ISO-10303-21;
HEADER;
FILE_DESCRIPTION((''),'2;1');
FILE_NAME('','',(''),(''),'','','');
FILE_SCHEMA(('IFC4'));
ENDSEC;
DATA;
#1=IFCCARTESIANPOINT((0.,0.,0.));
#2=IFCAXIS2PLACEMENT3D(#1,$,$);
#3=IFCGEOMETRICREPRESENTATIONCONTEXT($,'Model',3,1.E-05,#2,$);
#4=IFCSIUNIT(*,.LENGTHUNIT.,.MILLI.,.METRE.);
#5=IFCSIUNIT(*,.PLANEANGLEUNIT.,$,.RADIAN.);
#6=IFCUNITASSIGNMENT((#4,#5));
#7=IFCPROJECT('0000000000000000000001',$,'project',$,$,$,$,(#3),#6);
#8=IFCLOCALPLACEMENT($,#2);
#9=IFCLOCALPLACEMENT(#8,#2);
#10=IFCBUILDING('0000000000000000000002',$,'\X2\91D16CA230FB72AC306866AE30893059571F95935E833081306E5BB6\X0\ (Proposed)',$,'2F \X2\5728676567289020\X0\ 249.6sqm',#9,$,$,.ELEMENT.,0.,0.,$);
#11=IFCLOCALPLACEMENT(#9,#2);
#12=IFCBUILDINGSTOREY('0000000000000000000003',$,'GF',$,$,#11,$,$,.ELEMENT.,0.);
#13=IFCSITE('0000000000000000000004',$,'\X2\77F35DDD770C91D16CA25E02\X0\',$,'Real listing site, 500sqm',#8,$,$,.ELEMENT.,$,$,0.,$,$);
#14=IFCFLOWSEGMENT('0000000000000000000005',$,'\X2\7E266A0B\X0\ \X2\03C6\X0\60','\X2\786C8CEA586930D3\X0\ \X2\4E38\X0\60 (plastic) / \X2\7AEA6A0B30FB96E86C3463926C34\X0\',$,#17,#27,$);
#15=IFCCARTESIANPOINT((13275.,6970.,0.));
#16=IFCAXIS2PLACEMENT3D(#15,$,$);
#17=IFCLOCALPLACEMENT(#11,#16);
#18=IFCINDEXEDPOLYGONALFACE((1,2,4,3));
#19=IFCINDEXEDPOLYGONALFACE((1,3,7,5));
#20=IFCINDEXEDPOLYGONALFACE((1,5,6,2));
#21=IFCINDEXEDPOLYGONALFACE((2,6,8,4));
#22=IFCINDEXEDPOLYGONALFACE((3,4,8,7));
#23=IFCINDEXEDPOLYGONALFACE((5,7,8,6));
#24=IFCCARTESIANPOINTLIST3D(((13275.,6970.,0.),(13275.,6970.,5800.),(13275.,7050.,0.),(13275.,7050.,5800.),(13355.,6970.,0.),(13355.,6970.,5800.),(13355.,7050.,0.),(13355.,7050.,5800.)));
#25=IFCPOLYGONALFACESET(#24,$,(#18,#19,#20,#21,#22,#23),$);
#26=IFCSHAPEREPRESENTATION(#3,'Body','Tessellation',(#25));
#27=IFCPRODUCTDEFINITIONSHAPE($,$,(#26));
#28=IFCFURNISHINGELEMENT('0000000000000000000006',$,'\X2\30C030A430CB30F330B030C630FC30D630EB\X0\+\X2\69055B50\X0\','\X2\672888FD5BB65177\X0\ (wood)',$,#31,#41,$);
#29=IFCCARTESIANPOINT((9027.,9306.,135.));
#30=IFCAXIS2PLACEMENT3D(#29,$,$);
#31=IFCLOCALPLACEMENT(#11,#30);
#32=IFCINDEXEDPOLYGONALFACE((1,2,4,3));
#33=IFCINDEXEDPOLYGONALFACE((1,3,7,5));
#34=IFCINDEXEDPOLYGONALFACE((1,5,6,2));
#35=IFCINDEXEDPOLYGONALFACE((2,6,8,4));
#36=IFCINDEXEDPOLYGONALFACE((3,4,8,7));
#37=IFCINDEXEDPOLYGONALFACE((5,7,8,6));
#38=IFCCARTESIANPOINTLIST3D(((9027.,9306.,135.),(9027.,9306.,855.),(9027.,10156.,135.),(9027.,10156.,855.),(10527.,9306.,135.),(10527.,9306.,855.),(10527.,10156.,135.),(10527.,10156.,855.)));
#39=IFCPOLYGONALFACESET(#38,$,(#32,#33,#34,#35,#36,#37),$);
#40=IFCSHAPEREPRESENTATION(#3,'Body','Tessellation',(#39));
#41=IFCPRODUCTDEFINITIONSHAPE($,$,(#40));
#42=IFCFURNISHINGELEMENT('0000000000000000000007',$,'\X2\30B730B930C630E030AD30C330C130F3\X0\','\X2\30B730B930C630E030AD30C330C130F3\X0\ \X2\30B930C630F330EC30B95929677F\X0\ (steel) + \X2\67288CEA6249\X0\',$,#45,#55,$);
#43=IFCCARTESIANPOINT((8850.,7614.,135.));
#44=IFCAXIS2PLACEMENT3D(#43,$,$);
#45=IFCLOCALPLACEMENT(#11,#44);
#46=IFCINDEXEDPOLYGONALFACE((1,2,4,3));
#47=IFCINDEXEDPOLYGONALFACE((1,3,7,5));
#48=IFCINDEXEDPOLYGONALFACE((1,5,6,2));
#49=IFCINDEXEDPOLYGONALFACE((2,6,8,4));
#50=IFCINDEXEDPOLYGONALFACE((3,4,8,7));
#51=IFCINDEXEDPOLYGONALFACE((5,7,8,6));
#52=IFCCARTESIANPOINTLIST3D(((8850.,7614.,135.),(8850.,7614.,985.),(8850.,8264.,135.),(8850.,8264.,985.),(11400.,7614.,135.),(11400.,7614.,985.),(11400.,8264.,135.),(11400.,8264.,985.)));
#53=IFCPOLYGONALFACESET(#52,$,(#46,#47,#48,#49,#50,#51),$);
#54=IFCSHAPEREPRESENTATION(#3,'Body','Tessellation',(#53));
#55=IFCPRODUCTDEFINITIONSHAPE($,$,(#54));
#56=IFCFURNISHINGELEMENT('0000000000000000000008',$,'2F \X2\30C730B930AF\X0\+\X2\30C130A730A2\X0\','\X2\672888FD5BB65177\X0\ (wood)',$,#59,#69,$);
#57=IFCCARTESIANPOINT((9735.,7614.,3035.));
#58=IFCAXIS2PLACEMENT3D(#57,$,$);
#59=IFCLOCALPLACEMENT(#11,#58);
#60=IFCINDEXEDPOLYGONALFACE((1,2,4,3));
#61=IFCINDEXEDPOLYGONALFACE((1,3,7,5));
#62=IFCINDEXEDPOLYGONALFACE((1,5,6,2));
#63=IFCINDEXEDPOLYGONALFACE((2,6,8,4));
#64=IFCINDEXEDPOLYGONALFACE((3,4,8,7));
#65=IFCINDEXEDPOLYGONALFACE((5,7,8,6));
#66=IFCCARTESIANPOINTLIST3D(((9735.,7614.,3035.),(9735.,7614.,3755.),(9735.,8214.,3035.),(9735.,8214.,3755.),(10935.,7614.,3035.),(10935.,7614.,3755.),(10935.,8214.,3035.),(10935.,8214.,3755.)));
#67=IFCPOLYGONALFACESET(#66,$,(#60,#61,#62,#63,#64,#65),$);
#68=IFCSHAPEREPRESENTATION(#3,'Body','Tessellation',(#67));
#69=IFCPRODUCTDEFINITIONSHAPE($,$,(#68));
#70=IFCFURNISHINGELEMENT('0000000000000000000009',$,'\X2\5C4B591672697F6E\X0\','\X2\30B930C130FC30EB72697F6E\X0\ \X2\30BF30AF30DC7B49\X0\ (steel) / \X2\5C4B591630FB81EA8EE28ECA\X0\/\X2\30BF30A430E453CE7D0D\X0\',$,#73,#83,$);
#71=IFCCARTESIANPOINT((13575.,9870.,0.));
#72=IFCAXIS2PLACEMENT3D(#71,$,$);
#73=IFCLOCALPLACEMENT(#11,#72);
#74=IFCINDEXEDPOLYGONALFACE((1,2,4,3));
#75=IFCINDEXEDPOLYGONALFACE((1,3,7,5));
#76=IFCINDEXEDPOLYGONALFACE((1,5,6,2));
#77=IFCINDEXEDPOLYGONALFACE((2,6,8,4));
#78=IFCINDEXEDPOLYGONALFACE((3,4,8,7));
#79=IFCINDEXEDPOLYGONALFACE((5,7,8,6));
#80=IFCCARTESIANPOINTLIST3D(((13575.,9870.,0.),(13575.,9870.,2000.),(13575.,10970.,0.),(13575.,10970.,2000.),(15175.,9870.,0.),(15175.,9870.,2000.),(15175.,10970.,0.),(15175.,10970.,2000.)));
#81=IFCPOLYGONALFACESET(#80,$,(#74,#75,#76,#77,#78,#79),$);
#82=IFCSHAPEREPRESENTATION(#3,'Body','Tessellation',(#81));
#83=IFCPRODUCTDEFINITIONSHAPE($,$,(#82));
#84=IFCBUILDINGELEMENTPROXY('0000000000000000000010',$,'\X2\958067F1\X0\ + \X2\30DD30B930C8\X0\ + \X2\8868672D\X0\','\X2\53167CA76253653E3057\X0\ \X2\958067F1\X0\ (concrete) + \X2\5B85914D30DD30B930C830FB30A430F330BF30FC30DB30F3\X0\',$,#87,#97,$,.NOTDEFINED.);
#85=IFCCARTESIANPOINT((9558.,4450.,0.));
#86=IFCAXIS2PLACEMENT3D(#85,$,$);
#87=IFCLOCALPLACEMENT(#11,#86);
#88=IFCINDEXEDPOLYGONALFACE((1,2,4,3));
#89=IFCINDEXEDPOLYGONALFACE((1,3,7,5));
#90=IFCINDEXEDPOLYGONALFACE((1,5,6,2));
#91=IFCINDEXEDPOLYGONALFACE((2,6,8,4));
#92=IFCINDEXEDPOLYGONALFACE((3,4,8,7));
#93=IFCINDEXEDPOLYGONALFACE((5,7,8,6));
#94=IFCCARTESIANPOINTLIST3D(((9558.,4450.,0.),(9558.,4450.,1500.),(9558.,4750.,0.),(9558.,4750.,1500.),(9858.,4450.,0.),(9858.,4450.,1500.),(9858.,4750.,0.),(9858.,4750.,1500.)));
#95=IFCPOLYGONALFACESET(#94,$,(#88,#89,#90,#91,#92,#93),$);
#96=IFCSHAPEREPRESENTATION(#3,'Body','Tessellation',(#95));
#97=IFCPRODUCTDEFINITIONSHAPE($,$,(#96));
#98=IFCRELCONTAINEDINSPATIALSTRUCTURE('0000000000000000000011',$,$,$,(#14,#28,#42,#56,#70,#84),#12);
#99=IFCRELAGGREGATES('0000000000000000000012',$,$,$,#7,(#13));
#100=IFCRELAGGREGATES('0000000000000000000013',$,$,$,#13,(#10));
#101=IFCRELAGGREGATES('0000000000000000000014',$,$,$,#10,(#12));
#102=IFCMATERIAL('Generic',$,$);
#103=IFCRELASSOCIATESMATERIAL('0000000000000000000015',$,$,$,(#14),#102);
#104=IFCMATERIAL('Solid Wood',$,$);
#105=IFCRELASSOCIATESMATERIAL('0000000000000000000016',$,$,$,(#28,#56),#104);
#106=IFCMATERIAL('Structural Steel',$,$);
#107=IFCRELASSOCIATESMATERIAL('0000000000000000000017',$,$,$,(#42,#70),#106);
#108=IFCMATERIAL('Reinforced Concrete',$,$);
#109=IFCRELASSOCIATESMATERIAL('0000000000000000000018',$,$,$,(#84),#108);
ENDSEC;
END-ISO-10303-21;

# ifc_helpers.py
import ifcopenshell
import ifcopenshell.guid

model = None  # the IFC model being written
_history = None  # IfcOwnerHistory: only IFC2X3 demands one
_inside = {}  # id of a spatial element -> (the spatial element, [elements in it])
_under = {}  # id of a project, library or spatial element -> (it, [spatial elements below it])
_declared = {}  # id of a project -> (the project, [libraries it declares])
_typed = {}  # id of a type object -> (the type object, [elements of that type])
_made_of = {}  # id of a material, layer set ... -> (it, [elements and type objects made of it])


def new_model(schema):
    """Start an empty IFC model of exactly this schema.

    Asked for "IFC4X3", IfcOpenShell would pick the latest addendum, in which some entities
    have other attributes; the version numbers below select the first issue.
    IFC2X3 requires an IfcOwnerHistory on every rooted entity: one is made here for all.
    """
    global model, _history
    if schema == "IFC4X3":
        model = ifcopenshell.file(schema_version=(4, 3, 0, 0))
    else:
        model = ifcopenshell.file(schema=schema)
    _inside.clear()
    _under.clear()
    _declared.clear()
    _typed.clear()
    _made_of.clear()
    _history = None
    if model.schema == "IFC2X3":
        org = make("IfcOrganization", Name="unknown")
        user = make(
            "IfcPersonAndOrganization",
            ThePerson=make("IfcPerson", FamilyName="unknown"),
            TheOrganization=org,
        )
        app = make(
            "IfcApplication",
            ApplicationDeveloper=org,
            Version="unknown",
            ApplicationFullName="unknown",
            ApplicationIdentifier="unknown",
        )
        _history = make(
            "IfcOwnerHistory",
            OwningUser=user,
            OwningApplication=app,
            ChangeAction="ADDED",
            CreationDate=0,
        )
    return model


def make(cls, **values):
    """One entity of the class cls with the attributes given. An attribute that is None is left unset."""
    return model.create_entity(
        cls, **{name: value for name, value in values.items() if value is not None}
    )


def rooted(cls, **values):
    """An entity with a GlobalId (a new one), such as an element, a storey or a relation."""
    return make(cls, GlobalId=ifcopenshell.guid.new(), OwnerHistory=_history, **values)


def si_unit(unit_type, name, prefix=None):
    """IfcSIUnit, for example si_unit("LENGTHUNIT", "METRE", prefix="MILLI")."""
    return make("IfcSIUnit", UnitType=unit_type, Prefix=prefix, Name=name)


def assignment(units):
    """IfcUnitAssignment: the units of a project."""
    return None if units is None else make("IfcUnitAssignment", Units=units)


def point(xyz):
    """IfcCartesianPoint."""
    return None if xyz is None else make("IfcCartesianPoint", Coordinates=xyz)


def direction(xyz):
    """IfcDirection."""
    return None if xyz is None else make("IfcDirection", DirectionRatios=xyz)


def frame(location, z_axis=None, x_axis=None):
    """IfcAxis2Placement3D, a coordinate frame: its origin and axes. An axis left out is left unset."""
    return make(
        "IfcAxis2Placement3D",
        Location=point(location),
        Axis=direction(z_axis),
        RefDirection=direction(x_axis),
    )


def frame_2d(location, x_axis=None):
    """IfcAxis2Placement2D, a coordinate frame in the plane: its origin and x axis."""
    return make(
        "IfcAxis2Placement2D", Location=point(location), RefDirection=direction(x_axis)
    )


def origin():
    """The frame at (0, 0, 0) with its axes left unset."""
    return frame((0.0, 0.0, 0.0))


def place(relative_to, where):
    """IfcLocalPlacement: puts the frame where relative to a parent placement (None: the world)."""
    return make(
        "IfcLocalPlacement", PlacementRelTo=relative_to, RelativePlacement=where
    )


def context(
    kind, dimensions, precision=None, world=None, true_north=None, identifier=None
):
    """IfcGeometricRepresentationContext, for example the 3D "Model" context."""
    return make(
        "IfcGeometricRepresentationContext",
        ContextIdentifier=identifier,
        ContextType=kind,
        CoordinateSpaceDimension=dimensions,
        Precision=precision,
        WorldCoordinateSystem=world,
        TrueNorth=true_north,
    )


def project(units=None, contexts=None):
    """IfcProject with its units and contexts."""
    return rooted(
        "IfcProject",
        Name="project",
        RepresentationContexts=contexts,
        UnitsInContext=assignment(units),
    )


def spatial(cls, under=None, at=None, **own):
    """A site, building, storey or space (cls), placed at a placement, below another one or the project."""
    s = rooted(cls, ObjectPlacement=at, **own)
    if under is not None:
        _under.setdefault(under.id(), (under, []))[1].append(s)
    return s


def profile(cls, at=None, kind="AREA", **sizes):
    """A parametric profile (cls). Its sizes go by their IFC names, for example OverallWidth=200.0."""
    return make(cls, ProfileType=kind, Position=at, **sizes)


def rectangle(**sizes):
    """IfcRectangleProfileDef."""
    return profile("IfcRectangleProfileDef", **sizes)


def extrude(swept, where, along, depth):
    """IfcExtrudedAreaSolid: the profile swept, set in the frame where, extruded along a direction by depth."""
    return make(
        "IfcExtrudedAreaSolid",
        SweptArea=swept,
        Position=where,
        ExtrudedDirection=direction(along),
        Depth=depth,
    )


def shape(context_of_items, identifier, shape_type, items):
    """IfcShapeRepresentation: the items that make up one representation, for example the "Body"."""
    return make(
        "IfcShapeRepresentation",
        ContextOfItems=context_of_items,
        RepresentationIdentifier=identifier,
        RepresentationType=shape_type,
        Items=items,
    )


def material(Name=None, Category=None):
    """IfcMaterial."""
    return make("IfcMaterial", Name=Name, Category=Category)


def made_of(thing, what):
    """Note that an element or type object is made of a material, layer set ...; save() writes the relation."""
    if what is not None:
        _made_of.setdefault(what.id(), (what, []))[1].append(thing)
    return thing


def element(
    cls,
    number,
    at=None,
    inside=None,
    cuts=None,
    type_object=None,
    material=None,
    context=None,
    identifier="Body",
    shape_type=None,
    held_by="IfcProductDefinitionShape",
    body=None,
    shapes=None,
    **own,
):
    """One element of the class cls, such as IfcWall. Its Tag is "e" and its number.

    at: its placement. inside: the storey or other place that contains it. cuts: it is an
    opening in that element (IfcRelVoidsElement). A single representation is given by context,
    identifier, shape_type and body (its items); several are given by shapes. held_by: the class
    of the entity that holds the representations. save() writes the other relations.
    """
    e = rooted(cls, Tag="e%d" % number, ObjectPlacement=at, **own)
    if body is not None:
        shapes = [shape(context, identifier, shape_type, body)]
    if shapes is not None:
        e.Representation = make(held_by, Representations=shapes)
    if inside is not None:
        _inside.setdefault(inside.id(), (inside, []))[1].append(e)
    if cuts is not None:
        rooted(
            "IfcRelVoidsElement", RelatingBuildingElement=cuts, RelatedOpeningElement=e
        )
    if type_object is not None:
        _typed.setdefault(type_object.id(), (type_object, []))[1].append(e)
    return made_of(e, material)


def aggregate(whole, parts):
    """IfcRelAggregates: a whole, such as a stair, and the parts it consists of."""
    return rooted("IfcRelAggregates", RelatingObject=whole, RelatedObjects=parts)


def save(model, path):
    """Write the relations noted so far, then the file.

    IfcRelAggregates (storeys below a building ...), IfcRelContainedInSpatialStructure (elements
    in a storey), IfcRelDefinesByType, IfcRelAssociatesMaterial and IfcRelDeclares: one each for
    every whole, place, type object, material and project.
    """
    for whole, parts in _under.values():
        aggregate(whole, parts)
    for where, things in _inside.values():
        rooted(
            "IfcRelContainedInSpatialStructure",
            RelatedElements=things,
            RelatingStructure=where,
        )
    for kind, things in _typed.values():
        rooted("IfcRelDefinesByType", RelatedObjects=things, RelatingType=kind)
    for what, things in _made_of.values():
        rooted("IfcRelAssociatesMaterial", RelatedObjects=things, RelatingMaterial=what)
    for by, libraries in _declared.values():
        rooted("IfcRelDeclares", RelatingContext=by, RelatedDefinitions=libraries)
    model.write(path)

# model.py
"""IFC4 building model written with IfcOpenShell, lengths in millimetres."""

from ifc_helpers import new_model, si_unit, frame, frame_2d, origin, place, context, project, spatial, rectangle, extrude, material, element, save


model = new_model("IFC4")

# Units and contexts
model_context = context("Model", 3, precision=1e-05, world=origin())
ifc_project = project(units=[si_unit("LENGTHUNIT", "METRE", prefix="MILLI"), si_unit("PLANEANGLEUNIT", "RADIAN")], contexts=[model_context])

# Site, building, storey
site_placement = place(None, origin())
site = spatial("IfcSite", under=ifc_project, at=site_placement, Name="石川県金沢市", ObjectType="Real listing site, 500sqm", CompositionType="ELEMENT", RefElevation=0.0)
building_placement = place(site_placement, origin())
building = spatial("IfcBuilding", under=site, at=building_placement, Name="金沢・犬と暮らす土間広めの家 (Proposed)", ObjectType="2F 在来木造 249.6sqm", CompositionType="ELEMENT", ElevationOfRefHeight=0.0, ElevationOfTerrain=0.0)
storey_placement = place(building_placement, origin())
storey = spatial("IfcBuildingStorey", under=building, at=storey_placement, Name="GF", CompositionType="ELEMENT", Elevation=0.0)

# Shared definitions
ifc_material_1 = material(Name="Solid Wood")

# Shared definitions
ifc_material_2 = material(Name="Reinforced Concrete")

# Shared definitions
ifc_material_3 = material(Name="Structural Steel")

# Shared definitions
ifc_material_4 = material(Name="Generic")

# Flow segment
flow_segment_placement = place(storey_placement, frame((13275.0, 6970.0, 0.0)))
element("IfcFlowSegment", 1, at=flow_segment_placement, inside=storey, material=ifc_material_4, Name="縦樋 φ60", Description="硬質塩ビ 丸60 (plastic) / 竪樋・雨水排水", context=model_context, shape_type="SweptSolid", body=[
    extrude(rectangle(XDim=80.0, YDim=80.0, at=frame_2d((40.0, 40.0))), frame((13275.0, 6970.0, 0.0)), (0.0, 0.0, 1.0), 5800.0),
])

# Furnishing elements
furnishing_1_placement = place(storey_placement, frame((9027.0, 9306.0, 135.0)))
element("IfcFurnishingElement", 2, at=furnishing_1_placement, inside=storey, material=ifc_material_1, Name="ダイニングテーブル+椅子", Description="木製家具 (wood)", context=model_context, shape_type="SweptSolid", body=[
    extrude(rectangle(XDim=1500.0, YDim=850.0, at=frame_2d((750.0, 425.0))), frame((9027.0, 9306.0, 135.0)), (0.0, 0.0, 1.0), 720.0),
])
furnishing_2_placement = place(storey_placement, frame((8850.0, 7614.0, 135.0)))
element("IfcFurnishingElement", 3, at=furnishing_2_placement, inside=storey, material=ifc_material_3, Name="システムキッチン", Description="システムキッチン ステンレス天板 (steel) + 木質扉", context=model_context, shape_type="SweptSolid", body=[
    extrude(rectangle(XDim=2550.0, YDim=650.0, at=frame_2d((1275.0, 325.0))), frame((8850.0, 7614.0, 135.0)), (0.0, 0.0, 1.0), 850.0),
])
furnishing_3_placement = place(storey_placement, frame((9735.0, 7614.0, 3035.0)))
element("IfcFurnishingElement", 4, at=furnishing_3_placement, inside=storey, material=ifc_material_1, Name="2F デスク+チェア", Description="木製家具 (wood)", context=model_context, shape_type="SweptSolid", body=[
    extrude(rectangle(XDim=1200.0, YDim=600.0, at=frame_2d((600.0, 300.0))), frame((9735.0, 7614.0, 3035.0)), (0.0, 0.0, 1.0), 720.0),
])
furnishing_4_placement = place(storey_placement, frame((13575.0, 9870.0, 0.0)))
element("IfcFurnishingElement", 5, at=furnishing_4_placement, inside=storey, material=ifc_material_3, Name="屋外物置", Description="スチール物置 タクボ等 (steel) / 屋外・自転車/タイヤ収納", context=model_context, shape_type="SweptSolid", body=[
    extrude(rectangle(XDim=1600.0, YDim=1100.0, at=frame_2d((800.0, 550.0))), frame((13575.0, 9870.0, 0.0)), (0.0, 0.0, 1.0), 2000.0),
])

# Building element proxy
proxy_placement = place(storey_placement, frame((9558.0, 4450.0, 0.0)))
element("IfcBuildingElementProxy", 6, at=proxy_placement, inside=storey, material=ifc_material_2, Name="門柱 + ポスト + 表札", Description="化粧打放し 門柱 (concrete) + 宅配ポスト・インターホン", PredefinedType="NOTDEFINED", context=model_context, shape_type="SweptSolid", body=[
    extrude(rectangle(XDim=300.0, YDim=300.0, at=frame_2d((150.0, 150.0))), frame((9558.0, 4450.0, 0.0)), (0.0, 0.0, 1.0), 1500.0),
])

save(model, "model.ifc")
